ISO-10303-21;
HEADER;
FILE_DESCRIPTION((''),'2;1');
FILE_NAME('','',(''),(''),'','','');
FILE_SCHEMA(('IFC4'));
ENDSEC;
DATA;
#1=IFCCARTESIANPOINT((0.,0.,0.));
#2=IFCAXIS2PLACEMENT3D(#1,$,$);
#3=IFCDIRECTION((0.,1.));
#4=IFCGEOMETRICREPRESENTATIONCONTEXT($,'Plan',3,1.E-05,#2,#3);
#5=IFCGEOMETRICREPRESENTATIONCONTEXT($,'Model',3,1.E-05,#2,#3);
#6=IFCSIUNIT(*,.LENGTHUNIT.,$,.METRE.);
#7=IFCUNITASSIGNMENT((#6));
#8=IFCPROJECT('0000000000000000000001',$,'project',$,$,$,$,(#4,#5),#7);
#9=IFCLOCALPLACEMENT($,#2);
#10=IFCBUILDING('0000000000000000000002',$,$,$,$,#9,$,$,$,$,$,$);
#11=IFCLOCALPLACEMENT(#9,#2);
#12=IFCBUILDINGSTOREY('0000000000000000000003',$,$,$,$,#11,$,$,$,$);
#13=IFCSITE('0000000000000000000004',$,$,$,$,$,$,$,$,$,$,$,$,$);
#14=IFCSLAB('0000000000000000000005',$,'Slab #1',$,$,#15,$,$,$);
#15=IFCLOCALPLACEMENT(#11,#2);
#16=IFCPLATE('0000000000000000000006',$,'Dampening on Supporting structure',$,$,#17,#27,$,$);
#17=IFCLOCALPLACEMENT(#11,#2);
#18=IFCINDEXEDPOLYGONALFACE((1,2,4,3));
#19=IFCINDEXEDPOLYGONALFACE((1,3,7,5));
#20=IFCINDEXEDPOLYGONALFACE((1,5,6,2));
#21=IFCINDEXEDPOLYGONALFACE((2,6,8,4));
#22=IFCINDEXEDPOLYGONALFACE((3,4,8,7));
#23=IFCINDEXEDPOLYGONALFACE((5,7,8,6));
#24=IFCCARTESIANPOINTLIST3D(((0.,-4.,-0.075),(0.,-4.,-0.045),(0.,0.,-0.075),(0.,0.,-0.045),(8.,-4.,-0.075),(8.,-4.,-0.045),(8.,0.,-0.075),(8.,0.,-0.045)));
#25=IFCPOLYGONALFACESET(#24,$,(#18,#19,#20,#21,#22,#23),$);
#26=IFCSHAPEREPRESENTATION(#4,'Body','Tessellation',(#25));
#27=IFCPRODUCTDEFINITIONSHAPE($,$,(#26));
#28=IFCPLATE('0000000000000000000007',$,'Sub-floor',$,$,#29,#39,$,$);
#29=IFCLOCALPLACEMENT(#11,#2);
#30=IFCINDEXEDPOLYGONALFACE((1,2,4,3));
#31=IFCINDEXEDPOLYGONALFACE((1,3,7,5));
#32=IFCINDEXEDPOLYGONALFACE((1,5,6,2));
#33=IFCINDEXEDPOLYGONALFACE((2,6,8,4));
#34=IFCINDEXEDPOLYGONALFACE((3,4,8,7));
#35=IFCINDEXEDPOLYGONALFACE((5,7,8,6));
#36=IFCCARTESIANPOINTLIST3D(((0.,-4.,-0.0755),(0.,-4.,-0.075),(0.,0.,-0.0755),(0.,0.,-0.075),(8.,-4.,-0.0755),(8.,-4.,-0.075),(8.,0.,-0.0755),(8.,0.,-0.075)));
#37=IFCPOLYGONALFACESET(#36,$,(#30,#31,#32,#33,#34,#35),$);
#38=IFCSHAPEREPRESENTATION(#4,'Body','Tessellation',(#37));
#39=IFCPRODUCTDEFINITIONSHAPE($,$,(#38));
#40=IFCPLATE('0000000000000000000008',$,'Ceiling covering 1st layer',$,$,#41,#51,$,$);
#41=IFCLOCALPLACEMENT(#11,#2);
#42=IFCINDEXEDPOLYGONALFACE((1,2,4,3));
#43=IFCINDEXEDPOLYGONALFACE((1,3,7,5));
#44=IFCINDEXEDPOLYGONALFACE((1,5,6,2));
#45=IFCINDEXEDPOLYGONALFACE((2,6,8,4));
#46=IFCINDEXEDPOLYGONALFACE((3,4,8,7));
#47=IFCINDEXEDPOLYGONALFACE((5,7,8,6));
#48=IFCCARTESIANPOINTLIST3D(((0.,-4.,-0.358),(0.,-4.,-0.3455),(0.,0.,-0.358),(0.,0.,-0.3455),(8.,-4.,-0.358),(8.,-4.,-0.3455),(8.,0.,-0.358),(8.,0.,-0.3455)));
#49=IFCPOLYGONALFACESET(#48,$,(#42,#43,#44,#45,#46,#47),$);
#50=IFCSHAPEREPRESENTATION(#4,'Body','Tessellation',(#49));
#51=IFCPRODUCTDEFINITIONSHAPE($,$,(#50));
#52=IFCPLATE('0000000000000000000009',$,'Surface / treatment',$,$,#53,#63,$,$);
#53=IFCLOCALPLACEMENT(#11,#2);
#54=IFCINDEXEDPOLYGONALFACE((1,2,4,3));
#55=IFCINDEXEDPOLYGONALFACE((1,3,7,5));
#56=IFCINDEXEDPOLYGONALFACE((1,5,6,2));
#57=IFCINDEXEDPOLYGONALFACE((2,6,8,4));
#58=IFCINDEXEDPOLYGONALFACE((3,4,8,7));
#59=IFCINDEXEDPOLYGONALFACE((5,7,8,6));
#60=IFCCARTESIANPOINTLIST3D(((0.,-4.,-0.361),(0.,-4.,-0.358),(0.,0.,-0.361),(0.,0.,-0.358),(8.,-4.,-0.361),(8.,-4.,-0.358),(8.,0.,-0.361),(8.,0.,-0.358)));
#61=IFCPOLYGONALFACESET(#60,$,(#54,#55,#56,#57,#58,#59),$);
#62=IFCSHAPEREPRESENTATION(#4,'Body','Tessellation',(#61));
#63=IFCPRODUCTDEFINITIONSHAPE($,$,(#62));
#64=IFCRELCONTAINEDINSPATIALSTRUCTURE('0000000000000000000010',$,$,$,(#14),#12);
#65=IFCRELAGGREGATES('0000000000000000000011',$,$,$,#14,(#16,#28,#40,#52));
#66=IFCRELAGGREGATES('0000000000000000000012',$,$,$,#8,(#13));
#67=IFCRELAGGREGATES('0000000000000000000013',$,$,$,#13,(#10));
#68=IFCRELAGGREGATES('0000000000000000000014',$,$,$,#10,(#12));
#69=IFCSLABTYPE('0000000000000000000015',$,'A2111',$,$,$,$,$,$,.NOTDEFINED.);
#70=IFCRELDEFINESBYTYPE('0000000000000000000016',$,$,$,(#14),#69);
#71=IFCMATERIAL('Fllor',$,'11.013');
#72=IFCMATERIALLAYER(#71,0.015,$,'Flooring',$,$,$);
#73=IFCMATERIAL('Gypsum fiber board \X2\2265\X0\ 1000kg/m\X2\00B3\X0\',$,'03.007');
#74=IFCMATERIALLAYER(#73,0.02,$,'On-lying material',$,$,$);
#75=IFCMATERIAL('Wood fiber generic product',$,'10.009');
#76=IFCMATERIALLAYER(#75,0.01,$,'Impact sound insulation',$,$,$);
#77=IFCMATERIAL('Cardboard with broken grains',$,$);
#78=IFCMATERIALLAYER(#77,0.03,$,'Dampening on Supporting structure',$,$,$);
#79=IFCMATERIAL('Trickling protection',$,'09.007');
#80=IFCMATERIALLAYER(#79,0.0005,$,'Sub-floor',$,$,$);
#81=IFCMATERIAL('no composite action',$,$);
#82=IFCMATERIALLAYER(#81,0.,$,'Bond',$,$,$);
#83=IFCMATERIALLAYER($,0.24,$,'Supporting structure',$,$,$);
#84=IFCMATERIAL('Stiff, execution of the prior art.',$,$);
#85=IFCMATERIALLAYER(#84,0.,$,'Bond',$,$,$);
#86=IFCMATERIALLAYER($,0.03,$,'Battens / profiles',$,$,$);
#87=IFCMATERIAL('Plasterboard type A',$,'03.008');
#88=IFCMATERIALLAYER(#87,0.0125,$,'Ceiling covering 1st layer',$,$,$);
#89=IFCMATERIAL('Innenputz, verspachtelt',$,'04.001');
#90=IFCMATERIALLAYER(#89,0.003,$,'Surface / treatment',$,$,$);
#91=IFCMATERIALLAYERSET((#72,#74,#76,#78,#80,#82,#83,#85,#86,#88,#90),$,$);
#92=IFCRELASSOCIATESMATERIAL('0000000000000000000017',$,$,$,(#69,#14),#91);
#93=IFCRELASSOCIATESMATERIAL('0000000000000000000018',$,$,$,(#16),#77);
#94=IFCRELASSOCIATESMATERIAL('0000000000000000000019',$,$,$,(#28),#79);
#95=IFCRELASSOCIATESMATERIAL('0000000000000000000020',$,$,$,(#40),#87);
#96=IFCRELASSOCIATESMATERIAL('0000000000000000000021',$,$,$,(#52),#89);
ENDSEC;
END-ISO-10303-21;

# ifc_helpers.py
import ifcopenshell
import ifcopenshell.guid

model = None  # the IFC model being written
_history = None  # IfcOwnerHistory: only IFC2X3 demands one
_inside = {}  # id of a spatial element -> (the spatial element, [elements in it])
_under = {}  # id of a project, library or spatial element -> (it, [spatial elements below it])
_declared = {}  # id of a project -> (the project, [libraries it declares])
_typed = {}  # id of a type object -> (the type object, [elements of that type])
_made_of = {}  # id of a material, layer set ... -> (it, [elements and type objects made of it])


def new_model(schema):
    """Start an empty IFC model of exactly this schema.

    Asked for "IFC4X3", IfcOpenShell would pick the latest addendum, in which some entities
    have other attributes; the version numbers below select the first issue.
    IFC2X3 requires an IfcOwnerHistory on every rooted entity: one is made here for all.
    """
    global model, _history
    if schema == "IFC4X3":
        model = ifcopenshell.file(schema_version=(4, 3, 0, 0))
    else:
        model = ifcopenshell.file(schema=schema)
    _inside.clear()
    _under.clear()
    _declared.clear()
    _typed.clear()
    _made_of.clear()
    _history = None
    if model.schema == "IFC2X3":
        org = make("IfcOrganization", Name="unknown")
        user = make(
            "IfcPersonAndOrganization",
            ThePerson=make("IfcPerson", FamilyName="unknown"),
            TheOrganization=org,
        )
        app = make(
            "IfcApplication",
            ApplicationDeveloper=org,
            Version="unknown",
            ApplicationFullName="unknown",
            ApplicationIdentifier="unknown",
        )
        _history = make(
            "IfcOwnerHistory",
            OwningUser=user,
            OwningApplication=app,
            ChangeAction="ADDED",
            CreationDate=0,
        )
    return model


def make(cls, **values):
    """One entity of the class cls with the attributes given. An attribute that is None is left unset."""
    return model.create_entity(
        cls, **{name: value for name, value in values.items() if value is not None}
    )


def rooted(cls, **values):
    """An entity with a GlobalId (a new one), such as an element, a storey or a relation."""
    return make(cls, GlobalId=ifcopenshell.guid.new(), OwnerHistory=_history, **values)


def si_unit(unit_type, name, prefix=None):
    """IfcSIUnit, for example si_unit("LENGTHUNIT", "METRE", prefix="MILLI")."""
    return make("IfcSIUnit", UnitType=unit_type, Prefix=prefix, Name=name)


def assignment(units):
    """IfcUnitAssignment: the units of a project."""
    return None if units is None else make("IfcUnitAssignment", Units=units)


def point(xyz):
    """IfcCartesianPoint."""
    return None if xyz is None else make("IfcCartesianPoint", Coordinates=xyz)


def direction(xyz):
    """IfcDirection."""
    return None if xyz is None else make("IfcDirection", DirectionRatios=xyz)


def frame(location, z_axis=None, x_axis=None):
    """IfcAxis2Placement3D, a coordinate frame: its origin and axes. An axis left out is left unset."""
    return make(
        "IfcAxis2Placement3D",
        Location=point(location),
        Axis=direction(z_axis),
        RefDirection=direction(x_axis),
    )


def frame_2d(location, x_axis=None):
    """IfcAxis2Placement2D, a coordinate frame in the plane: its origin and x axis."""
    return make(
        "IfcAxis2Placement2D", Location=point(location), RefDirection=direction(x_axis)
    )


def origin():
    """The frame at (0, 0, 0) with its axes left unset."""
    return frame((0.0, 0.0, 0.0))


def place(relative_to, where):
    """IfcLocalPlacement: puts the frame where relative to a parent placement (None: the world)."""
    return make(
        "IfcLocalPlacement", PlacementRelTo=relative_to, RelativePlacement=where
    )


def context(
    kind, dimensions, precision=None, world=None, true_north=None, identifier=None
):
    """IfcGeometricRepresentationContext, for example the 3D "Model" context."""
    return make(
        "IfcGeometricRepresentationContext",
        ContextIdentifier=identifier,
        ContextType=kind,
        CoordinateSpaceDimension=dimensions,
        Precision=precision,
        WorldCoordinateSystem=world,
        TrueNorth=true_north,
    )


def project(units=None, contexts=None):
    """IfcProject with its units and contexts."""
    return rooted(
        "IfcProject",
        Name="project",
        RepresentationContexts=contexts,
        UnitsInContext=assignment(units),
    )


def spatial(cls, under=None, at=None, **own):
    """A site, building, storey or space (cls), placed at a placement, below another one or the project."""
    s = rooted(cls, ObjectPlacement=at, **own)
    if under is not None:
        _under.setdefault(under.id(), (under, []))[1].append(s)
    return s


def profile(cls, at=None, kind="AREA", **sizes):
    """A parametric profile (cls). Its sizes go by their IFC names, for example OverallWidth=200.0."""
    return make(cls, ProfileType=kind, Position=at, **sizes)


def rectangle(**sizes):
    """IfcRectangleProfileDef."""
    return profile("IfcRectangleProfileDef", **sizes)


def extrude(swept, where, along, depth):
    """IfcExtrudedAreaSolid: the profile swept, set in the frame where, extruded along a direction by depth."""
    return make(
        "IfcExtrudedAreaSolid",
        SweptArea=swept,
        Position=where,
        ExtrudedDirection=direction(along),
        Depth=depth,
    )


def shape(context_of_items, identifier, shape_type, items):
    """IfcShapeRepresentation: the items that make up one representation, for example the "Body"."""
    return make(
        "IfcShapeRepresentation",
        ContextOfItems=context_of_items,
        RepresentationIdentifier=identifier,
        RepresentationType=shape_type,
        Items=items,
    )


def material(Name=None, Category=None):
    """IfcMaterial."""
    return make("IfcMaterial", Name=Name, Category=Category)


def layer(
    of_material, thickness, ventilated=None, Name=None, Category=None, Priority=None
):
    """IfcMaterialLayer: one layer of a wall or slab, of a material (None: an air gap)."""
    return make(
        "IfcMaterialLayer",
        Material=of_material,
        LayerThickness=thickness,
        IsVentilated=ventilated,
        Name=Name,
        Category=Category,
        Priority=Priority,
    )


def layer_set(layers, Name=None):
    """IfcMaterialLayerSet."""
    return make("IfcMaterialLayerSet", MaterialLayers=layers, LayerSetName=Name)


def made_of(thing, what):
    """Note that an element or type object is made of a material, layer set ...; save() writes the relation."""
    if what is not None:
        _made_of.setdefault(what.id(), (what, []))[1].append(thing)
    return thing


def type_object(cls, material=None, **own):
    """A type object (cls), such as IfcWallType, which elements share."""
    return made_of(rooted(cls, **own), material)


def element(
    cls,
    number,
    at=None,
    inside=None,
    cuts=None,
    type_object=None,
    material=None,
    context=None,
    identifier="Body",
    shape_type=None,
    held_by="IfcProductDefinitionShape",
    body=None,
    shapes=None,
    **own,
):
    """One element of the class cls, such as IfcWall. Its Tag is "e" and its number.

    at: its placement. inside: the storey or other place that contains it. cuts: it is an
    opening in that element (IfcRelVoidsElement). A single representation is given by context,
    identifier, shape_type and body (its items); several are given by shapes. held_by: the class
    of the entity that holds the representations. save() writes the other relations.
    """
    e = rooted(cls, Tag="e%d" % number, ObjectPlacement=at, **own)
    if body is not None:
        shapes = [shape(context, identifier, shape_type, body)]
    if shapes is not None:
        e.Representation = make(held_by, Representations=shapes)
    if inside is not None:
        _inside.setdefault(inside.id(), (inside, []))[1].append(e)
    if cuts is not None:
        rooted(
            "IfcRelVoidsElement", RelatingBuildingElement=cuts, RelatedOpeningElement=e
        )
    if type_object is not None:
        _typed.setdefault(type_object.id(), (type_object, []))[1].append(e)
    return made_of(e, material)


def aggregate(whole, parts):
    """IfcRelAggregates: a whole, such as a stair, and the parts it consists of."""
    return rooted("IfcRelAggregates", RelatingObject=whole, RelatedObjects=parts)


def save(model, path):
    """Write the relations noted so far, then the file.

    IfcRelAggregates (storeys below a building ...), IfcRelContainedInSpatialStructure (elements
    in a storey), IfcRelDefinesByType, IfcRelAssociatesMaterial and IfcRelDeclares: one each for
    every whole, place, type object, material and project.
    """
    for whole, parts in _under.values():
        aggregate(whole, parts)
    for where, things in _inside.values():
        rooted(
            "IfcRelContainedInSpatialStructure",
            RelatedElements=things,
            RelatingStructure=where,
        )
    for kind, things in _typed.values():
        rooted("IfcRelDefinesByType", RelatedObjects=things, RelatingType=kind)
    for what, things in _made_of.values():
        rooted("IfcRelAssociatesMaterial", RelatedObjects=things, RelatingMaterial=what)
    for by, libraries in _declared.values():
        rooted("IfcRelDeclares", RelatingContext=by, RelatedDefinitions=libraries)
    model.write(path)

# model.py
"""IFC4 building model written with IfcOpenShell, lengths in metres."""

from ifc_helpers import new_model, si_unit, direction, frame, frame_2d, origin, place, context, project, spatial, rectangle, extrude, material, layer, layer_set, type_object, element, aggregate, save


model = new_model("IFC4")

# Units and contexts
plan_context = context("Plan", 3, precision=1e-05, world=origin(), true_north=direction((0.0, 1.0)))
model_context = context("Model", 3, precision=1e-05, world=origin(), true_north=direction((0.0, 1.0)))
ifc_project = project(units=[si_unit("LENGTHUNIT", "METRE")], contexts=[plan_context, model_context])

# Site, building, storey
site = spatial("IfcSite", under=ifc_project)
building_placement = place(None, origin())
building = spatial("IfcBuilding", under=site, at=building_placement)
storey_placement = place(building_placement, origin())
storey = spatial("IfcBuildingStorey", under=building, at=storey_placement)

# Slab, plates
ifc_material_1 = material(Name="Fllor", Category="11.013")
ifc_layer_1 = layer(ifc_material_1, 0.015, Name="Flooring")
ifc_material_2 = material(Name="Gypsum fiber board ≥ 1000kg/m³", Category="03.007")
ifc_layer_2 = layer(ifc_material_2, 0.02, Name="On-lying material")
ifc_material_3 = material(Name="Wood fiber generic product", Category="10.009")
ifc_layer_3 = layer(ifc_material_3, 0.01, Name="Impact sound insulation")
ifc_material_4 = material(Name="Cardboard with broken grains")
ifc_layer_4 = layer(ifc_material_4, 0.03, Name="Dampening on Supporting structure")
ifc_material_5 = material(Name="Trickling protection", Category="09.007")
ifc_layer_5 = layer(ifc_material_5, 0.0005, Name="Sub-floor")
ifc_material_6 = material(Name="no composite action")
ifc_layer_6 = layer(ifc_material_6, 0.0, Name="Bond")
ifc_layer_7 = layer(None, 0.24, Name="Supporting structure")
ifc_material_7 = material(Name="Stiff, execution of the prior art.")
ifc_layer_8 = layer(ifc_material_7, 0.0, Name="Bond")
ifc_layer_9 = layer(None, 0.03, Name="Battens / profiles")
ifc_material_8 = material(Name="Plasterboard type A", Category="03.008")
ifc_layer_10 = layer(ifc_material_8, 0.0125, Name="Ceiling covering 1st layer")
ifc_material_9 = material(Name="Innenputz, verspachtelt", Category="04.001")
ifc_layer_11 = layer(ifc_material_9, 0.003, Name="Surface / treatment")
ifc_layer_set = layer_set([ifc_layer_1, ifc_layer_2, ifc_layer_3, ifc_layer_4, ifc_layer_5, ifc_layer_6, ifc_layer_7, ifc_layer_8, ifc_layer_9, ifc_layer_10, ifc_layer_11])
slab_type = type_object("IfcSlabType", Name="A2111", PredefinedType="NOTDEFINED", material=ifc_layer_set)
slab_placement = place(None, frame((0.0, 0.0, 0.0), z_axis=(0.0, 0.0, -1.0), x_axis=(1.0, 0.0, 0.0)))
slab = element("IfcSlab", 1, at=slab_placement, inside=storey, type_object=slab_type, material=ifc_layer_set, Name="Slab #1")
plate_1_placement = place(slab_placement, origin())
plate_1 = element("IfcPlate", 2, at=plate_1_placement, material=ifc_material_4, Name="Dampening on Supporting structure", context=plan_context, shape_type="SweptSolid", body=[
    extrude(rectangle(XDim=8.0, YDim=4.0, at=frame_2d((4.0, 2.0), x_axis=(1.0, 0.0))), frame((0.0, 0.0, 0.045), z_axis=(0.0, 0.0, 1.0), x_axis=(1.0, 0.0, 0.0)), (0.0, 0.0, 1.0), 0.03),
])
plate_2_placement = place(slab_placement, origin())
plate_2 = element("IfcPlate", 3, at=plate_2_placement, material=ifc_material_5, Name="Sub-floor", context=plan_context, shape_type="SweptSolid", body=[
    extrude(rectangle(XDim=8.0, YDim=4.0, at=frame_2d((4.0, 2.0), x_axis=(1.0, 0.0))), frame((0.0, 0.0, 0.075), z_axis=(0.0, 0.0, 1.0), x_axis=(1.0, 0.0, 0.0)), (0.0, 0.0, 1.0), 0.0005),
])
plate_3_placement = place(slab_placement, origin())
plate_3 = element("IfcPlate", 4, at=plate_3_placement, material=ifc_material_8, Name="Ceiling covering 1st layer", context=plan_context, shape_type="SweptSolid", body=[
    extrude(rectangle(XDim=8.0, YDim=4.0, at=frame_2d((4.0, 2.0), x_axis=(1.0, 0.0))), frame((0.0, 0.0, 0.3455), z_axis=(0.0, 0.0, 1.0), x_axis=(1.0, 0.0, 0.0)), (0.0, 0.0, 1.0), 0.0125),
])
plate_4_placement = place(slab_placement, origin())
plate_4 = element("IfcPlate", 5, at=plate_4_placement, material=ifc_material_9, Name="Surface / treatment", context=plan_context, shape_type="SweptSolid", body=[
    extrude(rectangle(XDim=8.0, YDim=4.0, at=frame_2d((4.0, 2.0), x_axis=(1.0, 0.0))), frame((0.0, 0.0, 0.358), z_axis=(0.0, 0.0, 1.0), x_axis=(1.0, 0.0, 0.0)), (0.0, 0.0, 1.0), 0.003),
])
aggregate(slab, [plate_1, plate_2, plate_3, plate_4])

save(model, "model.ifc")
